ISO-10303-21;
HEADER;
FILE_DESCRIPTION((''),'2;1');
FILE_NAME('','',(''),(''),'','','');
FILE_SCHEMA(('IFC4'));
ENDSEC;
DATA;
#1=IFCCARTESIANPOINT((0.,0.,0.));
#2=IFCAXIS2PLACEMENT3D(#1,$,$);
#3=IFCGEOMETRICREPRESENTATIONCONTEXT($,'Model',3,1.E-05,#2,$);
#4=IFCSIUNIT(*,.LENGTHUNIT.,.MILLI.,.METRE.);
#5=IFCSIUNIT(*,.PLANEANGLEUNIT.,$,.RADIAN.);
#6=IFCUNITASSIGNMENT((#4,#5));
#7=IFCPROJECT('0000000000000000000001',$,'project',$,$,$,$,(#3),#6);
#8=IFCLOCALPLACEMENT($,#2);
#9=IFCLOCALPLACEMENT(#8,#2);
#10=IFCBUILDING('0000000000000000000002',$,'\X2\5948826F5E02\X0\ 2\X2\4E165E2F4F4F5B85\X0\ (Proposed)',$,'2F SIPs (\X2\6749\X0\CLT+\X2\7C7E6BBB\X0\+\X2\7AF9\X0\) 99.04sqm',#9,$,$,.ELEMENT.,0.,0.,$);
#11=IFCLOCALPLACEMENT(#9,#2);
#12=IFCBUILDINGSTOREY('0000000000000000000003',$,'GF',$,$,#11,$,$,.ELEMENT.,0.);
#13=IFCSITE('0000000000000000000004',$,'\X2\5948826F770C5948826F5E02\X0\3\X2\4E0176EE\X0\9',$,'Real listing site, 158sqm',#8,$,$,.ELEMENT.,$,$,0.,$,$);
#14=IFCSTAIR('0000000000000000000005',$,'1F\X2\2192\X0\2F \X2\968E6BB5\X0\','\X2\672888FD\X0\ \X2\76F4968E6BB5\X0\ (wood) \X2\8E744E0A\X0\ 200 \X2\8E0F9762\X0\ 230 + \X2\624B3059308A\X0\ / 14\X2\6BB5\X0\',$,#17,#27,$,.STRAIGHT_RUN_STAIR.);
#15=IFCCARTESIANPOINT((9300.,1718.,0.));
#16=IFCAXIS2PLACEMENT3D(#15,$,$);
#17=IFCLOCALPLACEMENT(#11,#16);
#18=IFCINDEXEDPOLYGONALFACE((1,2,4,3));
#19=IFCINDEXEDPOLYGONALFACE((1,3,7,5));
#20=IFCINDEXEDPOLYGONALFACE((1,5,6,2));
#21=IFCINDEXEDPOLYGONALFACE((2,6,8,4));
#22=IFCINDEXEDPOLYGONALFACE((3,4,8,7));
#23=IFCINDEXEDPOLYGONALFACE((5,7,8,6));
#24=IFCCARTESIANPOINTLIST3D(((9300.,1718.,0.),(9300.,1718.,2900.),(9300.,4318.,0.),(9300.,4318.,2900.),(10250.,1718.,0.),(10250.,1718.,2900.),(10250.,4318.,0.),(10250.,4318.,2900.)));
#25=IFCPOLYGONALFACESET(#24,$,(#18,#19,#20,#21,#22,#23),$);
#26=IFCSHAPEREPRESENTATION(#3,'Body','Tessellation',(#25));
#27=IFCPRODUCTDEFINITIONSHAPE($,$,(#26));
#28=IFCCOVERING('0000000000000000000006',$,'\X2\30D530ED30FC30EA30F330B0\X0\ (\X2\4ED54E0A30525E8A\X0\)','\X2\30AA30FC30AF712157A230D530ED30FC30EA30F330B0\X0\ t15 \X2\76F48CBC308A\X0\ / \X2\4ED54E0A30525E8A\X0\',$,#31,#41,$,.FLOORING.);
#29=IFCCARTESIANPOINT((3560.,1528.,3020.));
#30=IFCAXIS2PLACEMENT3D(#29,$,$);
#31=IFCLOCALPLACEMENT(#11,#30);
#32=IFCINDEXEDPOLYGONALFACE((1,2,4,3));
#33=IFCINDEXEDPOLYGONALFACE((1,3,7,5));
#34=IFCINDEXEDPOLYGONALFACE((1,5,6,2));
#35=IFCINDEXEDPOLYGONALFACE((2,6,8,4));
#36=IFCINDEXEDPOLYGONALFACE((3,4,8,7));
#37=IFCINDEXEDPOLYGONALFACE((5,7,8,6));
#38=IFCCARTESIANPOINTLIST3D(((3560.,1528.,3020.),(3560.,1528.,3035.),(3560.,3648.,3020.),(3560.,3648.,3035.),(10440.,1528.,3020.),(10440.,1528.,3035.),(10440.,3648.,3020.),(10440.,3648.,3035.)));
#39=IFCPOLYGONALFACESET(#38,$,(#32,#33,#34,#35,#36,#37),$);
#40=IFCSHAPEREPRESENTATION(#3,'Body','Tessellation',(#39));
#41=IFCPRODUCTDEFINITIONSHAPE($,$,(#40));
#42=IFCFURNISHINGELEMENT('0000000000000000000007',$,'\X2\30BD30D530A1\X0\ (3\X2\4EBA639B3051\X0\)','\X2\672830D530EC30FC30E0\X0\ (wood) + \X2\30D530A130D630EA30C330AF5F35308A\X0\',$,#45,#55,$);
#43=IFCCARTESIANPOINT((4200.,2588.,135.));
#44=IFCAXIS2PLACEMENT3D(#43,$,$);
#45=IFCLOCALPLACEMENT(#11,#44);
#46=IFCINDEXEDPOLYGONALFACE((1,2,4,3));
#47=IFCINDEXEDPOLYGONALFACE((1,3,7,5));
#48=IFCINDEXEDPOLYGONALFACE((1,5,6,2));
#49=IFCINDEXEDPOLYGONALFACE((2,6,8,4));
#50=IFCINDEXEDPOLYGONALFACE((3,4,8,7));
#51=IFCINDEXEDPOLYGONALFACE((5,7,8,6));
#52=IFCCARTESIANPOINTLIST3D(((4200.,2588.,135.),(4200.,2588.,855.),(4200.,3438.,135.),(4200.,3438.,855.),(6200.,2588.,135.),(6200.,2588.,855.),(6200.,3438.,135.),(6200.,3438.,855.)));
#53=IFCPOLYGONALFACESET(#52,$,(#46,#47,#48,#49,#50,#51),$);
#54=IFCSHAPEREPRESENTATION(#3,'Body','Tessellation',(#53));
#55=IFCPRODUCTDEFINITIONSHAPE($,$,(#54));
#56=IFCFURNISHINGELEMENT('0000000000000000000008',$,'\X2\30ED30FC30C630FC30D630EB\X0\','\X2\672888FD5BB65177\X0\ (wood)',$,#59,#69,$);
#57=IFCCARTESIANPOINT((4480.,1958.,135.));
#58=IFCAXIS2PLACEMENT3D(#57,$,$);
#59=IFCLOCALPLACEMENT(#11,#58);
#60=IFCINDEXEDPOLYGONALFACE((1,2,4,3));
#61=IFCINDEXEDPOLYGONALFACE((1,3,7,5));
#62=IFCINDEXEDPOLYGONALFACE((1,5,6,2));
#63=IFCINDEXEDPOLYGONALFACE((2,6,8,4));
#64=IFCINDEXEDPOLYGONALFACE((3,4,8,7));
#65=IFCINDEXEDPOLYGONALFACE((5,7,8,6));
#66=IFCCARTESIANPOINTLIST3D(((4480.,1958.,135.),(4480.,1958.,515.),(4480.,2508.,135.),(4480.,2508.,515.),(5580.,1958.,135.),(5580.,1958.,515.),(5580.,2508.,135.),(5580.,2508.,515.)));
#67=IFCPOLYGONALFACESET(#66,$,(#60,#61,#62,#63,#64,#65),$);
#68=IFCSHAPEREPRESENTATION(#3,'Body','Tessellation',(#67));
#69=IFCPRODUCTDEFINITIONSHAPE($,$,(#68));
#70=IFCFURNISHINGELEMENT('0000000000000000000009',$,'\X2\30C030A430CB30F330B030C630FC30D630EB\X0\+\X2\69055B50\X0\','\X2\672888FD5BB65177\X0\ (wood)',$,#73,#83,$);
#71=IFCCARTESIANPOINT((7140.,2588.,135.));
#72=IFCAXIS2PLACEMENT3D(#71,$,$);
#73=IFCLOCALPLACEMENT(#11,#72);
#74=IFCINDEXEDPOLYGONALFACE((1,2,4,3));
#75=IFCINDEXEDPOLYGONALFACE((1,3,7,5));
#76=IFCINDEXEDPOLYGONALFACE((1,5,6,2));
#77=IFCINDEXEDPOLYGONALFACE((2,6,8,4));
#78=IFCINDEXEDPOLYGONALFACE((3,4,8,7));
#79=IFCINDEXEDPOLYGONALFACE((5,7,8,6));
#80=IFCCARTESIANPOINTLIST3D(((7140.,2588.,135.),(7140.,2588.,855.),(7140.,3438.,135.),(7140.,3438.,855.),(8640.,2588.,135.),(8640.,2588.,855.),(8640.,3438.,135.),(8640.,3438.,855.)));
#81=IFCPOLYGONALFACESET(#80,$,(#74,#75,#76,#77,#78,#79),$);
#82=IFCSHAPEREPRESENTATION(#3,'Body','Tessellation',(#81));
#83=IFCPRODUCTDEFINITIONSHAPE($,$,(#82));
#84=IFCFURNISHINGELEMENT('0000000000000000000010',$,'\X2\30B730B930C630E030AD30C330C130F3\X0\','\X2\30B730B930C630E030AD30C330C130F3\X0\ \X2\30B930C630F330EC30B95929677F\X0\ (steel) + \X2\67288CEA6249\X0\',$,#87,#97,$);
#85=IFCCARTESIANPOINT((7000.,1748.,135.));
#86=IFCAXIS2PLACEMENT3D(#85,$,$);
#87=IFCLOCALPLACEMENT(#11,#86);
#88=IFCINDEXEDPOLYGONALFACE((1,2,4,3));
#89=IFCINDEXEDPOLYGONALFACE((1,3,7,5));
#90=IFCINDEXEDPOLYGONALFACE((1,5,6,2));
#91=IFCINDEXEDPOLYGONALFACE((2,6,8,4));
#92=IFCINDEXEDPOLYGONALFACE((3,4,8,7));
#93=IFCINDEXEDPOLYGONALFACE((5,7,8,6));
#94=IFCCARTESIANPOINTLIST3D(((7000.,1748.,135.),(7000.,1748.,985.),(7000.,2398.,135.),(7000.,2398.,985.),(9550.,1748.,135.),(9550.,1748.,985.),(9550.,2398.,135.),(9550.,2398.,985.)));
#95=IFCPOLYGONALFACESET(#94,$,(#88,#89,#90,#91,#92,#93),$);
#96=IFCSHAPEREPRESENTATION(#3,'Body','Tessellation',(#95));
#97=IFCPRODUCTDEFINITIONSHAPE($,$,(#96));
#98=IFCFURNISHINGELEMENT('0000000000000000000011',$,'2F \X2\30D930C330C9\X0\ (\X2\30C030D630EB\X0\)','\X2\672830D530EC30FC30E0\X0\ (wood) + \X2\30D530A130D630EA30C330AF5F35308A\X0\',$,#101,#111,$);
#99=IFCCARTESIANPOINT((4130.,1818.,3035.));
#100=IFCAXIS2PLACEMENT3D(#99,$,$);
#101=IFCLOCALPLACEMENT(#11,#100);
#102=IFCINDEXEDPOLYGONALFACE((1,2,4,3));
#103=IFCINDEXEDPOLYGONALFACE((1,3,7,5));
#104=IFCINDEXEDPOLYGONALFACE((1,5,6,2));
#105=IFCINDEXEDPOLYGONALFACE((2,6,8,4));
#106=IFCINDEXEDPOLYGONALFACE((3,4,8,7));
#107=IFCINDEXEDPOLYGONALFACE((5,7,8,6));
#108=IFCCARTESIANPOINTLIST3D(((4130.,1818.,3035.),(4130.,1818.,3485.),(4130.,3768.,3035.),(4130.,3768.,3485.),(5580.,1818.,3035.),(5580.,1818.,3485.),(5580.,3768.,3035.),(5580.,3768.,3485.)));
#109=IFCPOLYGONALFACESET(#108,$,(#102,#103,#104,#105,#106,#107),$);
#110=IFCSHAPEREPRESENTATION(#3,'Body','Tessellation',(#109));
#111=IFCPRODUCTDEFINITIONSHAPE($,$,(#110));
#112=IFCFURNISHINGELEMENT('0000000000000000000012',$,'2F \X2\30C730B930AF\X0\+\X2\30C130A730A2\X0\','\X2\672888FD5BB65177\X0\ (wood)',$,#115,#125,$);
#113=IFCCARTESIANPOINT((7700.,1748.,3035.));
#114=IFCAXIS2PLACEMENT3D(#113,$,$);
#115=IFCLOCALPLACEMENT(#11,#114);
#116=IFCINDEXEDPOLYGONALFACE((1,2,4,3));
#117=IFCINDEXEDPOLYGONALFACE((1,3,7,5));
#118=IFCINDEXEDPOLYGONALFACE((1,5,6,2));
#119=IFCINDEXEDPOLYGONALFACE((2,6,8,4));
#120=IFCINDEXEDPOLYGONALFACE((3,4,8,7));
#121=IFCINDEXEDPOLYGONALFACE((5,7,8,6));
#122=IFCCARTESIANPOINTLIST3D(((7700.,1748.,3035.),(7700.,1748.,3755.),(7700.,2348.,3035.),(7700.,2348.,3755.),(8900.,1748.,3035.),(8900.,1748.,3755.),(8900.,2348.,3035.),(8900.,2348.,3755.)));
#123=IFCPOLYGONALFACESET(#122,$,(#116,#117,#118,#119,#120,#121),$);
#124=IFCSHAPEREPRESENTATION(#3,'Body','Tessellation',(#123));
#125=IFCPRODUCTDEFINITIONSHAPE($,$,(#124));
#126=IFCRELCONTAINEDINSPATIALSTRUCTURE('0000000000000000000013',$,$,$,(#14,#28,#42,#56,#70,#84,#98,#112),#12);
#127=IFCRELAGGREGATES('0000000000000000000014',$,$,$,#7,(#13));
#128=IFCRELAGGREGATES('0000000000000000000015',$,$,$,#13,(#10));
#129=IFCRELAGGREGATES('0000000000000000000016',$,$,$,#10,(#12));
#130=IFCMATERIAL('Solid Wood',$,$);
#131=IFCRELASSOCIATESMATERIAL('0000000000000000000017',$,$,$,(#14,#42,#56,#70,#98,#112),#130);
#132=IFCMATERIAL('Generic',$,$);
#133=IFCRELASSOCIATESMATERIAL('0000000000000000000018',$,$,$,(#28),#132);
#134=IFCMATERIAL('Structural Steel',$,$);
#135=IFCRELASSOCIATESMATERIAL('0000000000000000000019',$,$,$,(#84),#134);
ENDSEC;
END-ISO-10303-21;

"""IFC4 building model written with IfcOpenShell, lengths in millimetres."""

from ifc_helpers import new_model, si_unit, frame, frame_2d, origin, place, context, project, spatial, rectangle, extrude, material, element, save


model = new_model("IFC4")

# Units and contexts
model_context = context("Model", 3, precision=1e-05, world=origin())
ifc_project = project(units=[si_unit("LENGTHUNIT", "METRE", prefix="MILLI"), si_unit("PLANEANGLEUNIT", "RADIAN")], contexts=[model_context])

# Site, building, storey
site_placement = place(None, origin())
site = spatial("IfcSite", under=ifc_project, at=site_placement, Name="奈良県奈良市3丁目9", ObjectType="Real listing site, 158sqm", CompositionType="ELEMENT", RefElevation=0.0)
building_placement = place(site_placement, origin())
building = spatial("IfcBuilding", under=site, at=building_placement, Name="奈良市 2世帯住宅 (Proposed)", ObjectType="2F SIPs (杉CLT+籾殻+竹) 99.04sqm", CompositionType="ELEMENT", ElevationOfRefHeight=0.0, ElevationOfTerrain=0.0)
storey_placement = place(building_placement, origin())
storey = spatial("IfcBuildingStorey", under=building, at=storey_placement, Name="GF", CompositionType="ELEMENT", Elevation=0.0)

# Shared definitions
ifc_material_1 = material(Name="Solid Wood")

# Shared definitions
ifc_material_2 = material(Name="Generic")

# Stair
stair_placement = place(storey_placement, frame((9300.0, 1718.0, 0.0)))
element("IfcStair", 1, at=stair_placement, inside=storey, material=ifc_material_1, Name="1F→2F 階段", Description="木製 直階段 (wood) 蹴上 200 踏面 230 + 手すり / 14段", PredefinedType="STRAIGHT_RUN_STAIR", context=model_context, shape_type="SweptSolid", body=[
    extrude(rectangle(XDim=950.0, YDim=2600.0, at=frame_2d((475.0, 1300.0))), frame((9300.0, 1718.0, 0.0)), (0.0, 0.0, 1.0), 2900.0),
])

# Covering
covering_placement = place(storey_placement, frame((3560.0, 1528.0, 3020.0)))
element("IfcCovering", 2, at=covering_placement, inside=storey, material=ifc_material_2, Name="フローリング (仕上げ床)", Description="オーク無垢フローリング t15 直貼り / 仕上げ床", PredefinedType="FLOORING", context=model_context, shape_type="SweptSolid", body=[
    extrude(rectangle(XDim=6880.0, YDim=2120.0, at=frame_2d((3440.0, 1060.0))), frame((3560.0, 1528.0, 3020.0)), (0.0, 0.0, 1.0), 15.0),
])

# Furnishing elements
furnishing_1_placement = place(storey_placement, frame((4200.0, 2588.0, 135.0)))
element("IfcFurnishingElement", 3, at=furnishing_1_placement, inside=storey, material=ifc_material_1, Name="ソファ (3人掛け)", Description="木フレーム (wood) + ファブリック張り", context=model_context, shape_type="SweptSolid", body=[
    extrude(rectangle(XDim=2000.0, YDim=850.0, at=frame_2d((1000.0, 425.0))), frame((4200.0, 2588.0, 135.0)), (0.0, 0.0, 1.0), 720.0),
])
furnishing_2_placement = place(storey_placement, frame((4480.0, 1958.0, 135.0)))
element("IfcFurnishingElement", 4, at=furnishing_2_placement, inside=storey, material=ifc_material_1, Name="ローテーブル", Description="木製家具 (wood)", context=model_context, shape_type="SweptSolid", body=[
    extrude(rectangle(XDim=1100.0, YDim=550.0, at=frame_2d((550.0, 275.0))), frame((4480.0, 1958.0, 135.0)), (0.0, 0.0, 1.0), 380.0),
])
furnishing_3_placement = place(storey_placement, frame((7140.0, 2588.0, 135.0)))
element("IfcFurnishingElement", 5, at=furnishing_3_placement, inside=storey, material=ifc_material_1, Name="ダイニングテーブル+椅子", Description="木製家具 (wood)", context=model_context, shape_type="SweptSolid", body=[
    extrude(rectangle(XDim=1500.0, YDim=850.0, at=frame_2d((750.0, 425.0))), frame((7140.0, 2588.0, 135.0)), (0.0, 0.0, 1.0), 720.0),
])
ifc_material_3 = material(Name="Structural Steel")
furnishing_4_placement = place(storey_placement, frame((7000.0, 1748.0, 135.0)))
element("IfcFurnishingElement", 6, at=furnishing_4_placement, inside=storey, material=ifc_material_3, Name="システムキッチン", Description="システムキッチン ステンレス天板 (steel) + 木質扉", context=model_context, shape_type="SweptSolid", body=[
    extrude(rectangle(XDim=2550.0, YDim=650.0, at=frame_2d((1275.0, 325.0))), frame((7000.0, 1748.0, 135.0)), (0.0, 0.0, 1.0), 850.0),
])
furnishing_5_placement = place(storey_placement, frame((4130.0, 1818.0, 3035.0)))
element("IfcFurnishingElement", 7, at=furnishing_5_placement, inside=storey, material=ifc_material_1, Name="2F ベッド (ダブル)", Description="木フレーム (wood) + ファブリック張り", context=model_context, shape_type="SweptSolid", body=[
    extrude(rectangle(XDim=1450.0, YDim=1950.0, at=frame_2d((725.0, 975.0))), frame((4130.0, 1818.0, 3035.0)), (0.0, 0.0, 1.0), 450.0),
])
furnishing_6_placement = place(storey_placement, frame((7700.0, 1748.0, 3035.0)))
element("IfcFurnishingElement", 8, at=furnishing_6_placement, inside=storey, material=ifc_material_1, Name="2F デスク+チェア", Description="木製家具 (wood)", context=model_context, shape_type="SweptSolid", body=[
    extrude(rectangle(XDim=1200.0, YDim=600.0, at=frame_2d((600.0, 300.0))), frame((7700.0, 1748.0, 3035.0)), (0.0, 0.0, 1.0), 720.0),
])

save(model, "model.ifc")
